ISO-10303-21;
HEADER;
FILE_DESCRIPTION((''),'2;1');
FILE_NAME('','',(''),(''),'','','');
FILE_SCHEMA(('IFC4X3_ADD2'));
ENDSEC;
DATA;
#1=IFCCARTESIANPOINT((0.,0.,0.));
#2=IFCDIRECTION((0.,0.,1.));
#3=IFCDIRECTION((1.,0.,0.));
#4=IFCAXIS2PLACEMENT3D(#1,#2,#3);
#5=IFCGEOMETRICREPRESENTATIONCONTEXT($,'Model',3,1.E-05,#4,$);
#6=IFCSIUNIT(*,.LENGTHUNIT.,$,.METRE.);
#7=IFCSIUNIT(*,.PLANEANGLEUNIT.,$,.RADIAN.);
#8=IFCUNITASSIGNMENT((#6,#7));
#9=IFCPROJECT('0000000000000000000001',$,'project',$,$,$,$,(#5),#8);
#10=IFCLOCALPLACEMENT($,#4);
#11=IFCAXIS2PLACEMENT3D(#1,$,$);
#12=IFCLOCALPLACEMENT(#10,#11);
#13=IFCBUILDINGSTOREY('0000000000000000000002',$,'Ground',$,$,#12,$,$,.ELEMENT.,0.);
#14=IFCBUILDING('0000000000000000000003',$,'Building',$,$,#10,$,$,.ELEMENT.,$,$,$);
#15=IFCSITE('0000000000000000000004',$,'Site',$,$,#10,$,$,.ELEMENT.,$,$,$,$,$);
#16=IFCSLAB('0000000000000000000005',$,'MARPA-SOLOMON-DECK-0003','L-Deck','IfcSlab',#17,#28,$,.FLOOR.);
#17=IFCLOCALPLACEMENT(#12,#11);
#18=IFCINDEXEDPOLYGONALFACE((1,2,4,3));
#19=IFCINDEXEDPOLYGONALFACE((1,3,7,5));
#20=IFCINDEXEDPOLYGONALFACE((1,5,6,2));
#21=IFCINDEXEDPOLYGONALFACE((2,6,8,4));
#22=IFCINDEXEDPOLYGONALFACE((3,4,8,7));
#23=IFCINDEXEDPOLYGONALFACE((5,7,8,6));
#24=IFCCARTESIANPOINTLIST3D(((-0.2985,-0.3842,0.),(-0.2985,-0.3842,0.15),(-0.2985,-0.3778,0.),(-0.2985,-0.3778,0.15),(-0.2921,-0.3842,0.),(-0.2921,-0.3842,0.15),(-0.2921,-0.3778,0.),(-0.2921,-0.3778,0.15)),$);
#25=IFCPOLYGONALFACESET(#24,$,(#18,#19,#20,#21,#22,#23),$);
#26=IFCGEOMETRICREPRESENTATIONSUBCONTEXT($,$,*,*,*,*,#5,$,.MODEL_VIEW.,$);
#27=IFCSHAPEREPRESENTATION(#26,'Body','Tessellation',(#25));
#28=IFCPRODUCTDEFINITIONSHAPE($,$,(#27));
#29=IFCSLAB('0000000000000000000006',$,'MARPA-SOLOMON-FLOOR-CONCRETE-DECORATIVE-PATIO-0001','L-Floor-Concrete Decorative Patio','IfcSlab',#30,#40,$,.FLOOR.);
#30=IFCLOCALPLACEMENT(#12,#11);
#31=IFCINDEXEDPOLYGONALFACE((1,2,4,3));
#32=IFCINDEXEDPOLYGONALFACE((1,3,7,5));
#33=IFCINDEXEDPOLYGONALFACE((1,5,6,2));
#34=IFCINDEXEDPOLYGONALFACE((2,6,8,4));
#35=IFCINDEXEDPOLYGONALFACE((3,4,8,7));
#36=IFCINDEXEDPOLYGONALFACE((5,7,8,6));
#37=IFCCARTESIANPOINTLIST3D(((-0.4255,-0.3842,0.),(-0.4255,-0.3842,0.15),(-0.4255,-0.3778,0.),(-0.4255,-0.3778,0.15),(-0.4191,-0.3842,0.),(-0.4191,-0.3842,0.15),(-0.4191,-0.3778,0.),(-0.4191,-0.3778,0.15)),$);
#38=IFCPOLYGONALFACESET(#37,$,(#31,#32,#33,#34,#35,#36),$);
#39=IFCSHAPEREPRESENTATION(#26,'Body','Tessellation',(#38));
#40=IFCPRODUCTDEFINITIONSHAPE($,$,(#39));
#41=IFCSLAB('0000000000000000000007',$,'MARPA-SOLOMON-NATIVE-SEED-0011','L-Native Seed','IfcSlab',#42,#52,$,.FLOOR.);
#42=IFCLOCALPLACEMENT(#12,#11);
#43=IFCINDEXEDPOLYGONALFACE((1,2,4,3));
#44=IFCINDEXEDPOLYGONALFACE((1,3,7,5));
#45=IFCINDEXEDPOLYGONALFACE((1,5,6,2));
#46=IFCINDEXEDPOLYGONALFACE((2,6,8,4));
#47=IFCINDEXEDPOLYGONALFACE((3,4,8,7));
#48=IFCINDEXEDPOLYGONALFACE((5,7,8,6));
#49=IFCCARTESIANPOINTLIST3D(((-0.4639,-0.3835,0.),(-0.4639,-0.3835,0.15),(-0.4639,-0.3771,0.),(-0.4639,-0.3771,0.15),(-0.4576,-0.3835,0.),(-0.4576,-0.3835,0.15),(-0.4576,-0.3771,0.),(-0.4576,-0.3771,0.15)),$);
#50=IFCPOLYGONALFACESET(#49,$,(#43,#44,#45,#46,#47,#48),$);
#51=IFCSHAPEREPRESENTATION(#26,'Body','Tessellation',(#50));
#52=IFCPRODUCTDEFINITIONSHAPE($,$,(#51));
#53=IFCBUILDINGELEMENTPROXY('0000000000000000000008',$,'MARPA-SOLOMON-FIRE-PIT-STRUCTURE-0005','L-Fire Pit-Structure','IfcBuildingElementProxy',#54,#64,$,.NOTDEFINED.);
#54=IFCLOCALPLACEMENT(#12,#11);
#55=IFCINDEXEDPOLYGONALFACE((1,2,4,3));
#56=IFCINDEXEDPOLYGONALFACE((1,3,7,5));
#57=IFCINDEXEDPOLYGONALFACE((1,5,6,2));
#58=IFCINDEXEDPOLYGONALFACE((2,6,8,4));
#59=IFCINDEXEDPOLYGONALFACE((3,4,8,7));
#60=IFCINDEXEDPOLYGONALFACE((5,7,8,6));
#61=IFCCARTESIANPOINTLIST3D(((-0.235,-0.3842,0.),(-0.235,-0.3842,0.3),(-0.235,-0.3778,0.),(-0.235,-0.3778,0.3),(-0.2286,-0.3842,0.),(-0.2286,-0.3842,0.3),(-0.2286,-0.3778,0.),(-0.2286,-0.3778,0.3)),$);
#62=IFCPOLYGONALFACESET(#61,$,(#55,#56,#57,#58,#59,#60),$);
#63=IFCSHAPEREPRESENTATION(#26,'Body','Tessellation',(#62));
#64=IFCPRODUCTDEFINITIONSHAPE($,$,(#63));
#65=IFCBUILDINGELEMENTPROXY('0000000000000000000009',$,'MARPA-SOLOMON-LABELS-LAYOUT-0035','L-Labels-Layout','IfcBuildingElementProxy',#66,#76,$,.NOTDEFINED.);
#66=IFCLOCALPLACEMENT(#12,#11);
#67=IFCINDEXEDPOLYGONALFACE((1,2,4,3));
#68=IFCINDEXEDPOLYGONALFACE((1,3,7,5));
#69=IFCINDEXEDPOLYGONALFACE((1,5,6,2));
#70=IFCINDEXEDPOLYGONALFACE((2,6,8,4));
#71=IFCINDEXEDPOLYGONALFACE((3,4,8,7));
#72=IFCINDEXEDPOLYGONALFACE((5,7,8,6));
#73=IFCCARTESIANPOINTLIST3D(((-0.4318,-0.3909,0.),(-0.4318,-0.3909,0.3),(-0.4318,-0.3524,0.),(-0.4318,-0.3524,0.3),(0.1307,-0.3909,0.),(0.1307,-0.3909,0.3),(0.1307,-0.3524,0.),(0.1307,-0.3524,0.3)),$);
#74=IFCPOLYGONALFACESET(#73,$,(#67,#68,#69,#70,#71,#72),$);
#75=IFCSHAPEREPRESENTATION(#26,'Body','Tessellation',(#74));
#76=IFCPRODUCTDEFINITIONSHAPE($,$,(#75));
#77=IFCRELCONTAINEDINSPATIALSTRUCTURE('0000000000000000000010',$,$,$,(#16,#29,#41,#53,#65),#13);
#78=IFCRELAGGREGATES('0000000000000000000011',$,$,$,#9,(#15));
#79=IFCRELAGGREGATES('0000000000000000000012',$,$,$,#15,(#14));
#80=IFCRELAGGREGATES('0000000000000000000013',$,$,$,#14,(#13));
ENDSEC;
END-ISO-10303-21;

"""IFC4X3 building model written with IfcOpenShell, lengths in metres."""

from ifc_helpers import new_model, si_unit, frame, origin, origin_with_axes, place, context, subcontext, project, spatial, polyline, outline, extrude, element, save


model = new_model("IFC4X3")

# Units and contexts
model_context = context("Model", 3, precision=1e-05, world=origin_with_axes())
sub_context = subcontext(model_context, None, None, "MODEL_VIEW")
ifc_project = project(units=[si_unit("LENGTHUNIT", "METRE"), si_unit("PLANEANGLEUNIT", "RADIAN")], contexts=[model_context])

# Site, building, storey
placement = place(None, origin_with_axes())
site = spatial("IfcSite", under=ifc_project, at=placement, Name="Site", CompositionType="ELEMENT")
building = spatial("IfcBuilding", under=site, at=placement, Name="Building", CompositionType="ELEMENT")
storey_placement = place(placement, origin())
storey = spatial("IfcBuildingStorey", under=building, at=storey_placement, Name="Ground", CompositionType="ELEMENT", Elevation=0.0)

# Slabs
for number, where, name, description in (
    (1, (-0.2985, -0.3842, 0.0), "MARPA-SOLOMON-DECK-0003", "L-Deck"),
    (2, (-0.4255, -0.3842, 0.0), "MARPA-SOLOMON-FLOOR-CONCRETE-DECORATIVE-PATIO-0001", "L-Floor-Concrete Decorative Patio"),
):
    element("IfcSlab", number, at=place(storey_placement, frame(where)), inside=storey, Name=name, Description=description, ObjectType="IfcSlab", PredefinedType="FLOOR", context=sub_context, shape_type="SweptSolid", body=[
        extrude(outline(polyline([(0.0, 0.0064), (0.0063, 0.0064), (0.0063, 0.0), (0.0, 0.0), (0.0, 0.0064)])), origin(), (0.0, 0.0, 1.0), 0.15),
    ])
for number, where, name in (
    (3, (-0.4639, -0.3835, 0.0), "MARPA-SOLOMON-NATIVE-SEED-0011"),
):
    element("IfcSlab", number, at=place(storey_placement, frame(where)), inside=storey, Name=name, Description="L-Native Seed", ObjectType="IfcSlab", PredefinedType="FLOOR", context=sub_context, shape_type="SweptSolid", body=[
        extrude(outline(polyline([(0.0, 0.0063), (0.0063, 0.0063), (0.0063, 0.0), (0.0, 0.0), (0.0, 0.0063)])), origin(), (0.0, 0.0, 1.0), 0.15),
    ])

# Building element proxies
proxy_placement = place(placement, frame((-0.235, -0.3842, 0.0)))
element("IfcBuildingElementProxy", 4, at=proxy_placement, inside=storey, Name="MARPA-SOLOMON-FIRE-PIT-STRUCTURE-0005", Description="L-Fire Pit-Structure", ObjectType="IfcBuildingElementProxy", PredefinedType="NOTDEFINED", context=sub_context, shape_type="SweptSolid", body=[
    extrude(outline(polyline([(0.0, 0.0064), (0.0063, 0.0064), (0.0063, 0.0), (0.0, 0.0), (0.0, 0.0064)])), origin(), (0.0, 0.0, 1.0), 0.3),
])
for number, where, name in (
    (5, (-0.4318, -0.3909, 0.0), "MARPA-SOLOMON-LABELS-LAYOUT-0035"),
):
    element("IfcBuildingElementProxy", number, at=place(placement, frame(where)), inside=storey, Name=name, Description="L-Labels-Layout", ObjectType="IfcBuildingElementProxy", PredefinedType="NOTDEFINED", context=sub_context, shape_type="SweptSolid", body=[
        extrude(outline(polyline([(0.0, 0.0385), (0.5625, 0.0385), (0.5625, 0.0), (0.0, 0.0), (0.0, 0.0385)])), origin(), (0.0, 0.0, 1.0), 0.3),
    ])

save(model, "model.ifc")
